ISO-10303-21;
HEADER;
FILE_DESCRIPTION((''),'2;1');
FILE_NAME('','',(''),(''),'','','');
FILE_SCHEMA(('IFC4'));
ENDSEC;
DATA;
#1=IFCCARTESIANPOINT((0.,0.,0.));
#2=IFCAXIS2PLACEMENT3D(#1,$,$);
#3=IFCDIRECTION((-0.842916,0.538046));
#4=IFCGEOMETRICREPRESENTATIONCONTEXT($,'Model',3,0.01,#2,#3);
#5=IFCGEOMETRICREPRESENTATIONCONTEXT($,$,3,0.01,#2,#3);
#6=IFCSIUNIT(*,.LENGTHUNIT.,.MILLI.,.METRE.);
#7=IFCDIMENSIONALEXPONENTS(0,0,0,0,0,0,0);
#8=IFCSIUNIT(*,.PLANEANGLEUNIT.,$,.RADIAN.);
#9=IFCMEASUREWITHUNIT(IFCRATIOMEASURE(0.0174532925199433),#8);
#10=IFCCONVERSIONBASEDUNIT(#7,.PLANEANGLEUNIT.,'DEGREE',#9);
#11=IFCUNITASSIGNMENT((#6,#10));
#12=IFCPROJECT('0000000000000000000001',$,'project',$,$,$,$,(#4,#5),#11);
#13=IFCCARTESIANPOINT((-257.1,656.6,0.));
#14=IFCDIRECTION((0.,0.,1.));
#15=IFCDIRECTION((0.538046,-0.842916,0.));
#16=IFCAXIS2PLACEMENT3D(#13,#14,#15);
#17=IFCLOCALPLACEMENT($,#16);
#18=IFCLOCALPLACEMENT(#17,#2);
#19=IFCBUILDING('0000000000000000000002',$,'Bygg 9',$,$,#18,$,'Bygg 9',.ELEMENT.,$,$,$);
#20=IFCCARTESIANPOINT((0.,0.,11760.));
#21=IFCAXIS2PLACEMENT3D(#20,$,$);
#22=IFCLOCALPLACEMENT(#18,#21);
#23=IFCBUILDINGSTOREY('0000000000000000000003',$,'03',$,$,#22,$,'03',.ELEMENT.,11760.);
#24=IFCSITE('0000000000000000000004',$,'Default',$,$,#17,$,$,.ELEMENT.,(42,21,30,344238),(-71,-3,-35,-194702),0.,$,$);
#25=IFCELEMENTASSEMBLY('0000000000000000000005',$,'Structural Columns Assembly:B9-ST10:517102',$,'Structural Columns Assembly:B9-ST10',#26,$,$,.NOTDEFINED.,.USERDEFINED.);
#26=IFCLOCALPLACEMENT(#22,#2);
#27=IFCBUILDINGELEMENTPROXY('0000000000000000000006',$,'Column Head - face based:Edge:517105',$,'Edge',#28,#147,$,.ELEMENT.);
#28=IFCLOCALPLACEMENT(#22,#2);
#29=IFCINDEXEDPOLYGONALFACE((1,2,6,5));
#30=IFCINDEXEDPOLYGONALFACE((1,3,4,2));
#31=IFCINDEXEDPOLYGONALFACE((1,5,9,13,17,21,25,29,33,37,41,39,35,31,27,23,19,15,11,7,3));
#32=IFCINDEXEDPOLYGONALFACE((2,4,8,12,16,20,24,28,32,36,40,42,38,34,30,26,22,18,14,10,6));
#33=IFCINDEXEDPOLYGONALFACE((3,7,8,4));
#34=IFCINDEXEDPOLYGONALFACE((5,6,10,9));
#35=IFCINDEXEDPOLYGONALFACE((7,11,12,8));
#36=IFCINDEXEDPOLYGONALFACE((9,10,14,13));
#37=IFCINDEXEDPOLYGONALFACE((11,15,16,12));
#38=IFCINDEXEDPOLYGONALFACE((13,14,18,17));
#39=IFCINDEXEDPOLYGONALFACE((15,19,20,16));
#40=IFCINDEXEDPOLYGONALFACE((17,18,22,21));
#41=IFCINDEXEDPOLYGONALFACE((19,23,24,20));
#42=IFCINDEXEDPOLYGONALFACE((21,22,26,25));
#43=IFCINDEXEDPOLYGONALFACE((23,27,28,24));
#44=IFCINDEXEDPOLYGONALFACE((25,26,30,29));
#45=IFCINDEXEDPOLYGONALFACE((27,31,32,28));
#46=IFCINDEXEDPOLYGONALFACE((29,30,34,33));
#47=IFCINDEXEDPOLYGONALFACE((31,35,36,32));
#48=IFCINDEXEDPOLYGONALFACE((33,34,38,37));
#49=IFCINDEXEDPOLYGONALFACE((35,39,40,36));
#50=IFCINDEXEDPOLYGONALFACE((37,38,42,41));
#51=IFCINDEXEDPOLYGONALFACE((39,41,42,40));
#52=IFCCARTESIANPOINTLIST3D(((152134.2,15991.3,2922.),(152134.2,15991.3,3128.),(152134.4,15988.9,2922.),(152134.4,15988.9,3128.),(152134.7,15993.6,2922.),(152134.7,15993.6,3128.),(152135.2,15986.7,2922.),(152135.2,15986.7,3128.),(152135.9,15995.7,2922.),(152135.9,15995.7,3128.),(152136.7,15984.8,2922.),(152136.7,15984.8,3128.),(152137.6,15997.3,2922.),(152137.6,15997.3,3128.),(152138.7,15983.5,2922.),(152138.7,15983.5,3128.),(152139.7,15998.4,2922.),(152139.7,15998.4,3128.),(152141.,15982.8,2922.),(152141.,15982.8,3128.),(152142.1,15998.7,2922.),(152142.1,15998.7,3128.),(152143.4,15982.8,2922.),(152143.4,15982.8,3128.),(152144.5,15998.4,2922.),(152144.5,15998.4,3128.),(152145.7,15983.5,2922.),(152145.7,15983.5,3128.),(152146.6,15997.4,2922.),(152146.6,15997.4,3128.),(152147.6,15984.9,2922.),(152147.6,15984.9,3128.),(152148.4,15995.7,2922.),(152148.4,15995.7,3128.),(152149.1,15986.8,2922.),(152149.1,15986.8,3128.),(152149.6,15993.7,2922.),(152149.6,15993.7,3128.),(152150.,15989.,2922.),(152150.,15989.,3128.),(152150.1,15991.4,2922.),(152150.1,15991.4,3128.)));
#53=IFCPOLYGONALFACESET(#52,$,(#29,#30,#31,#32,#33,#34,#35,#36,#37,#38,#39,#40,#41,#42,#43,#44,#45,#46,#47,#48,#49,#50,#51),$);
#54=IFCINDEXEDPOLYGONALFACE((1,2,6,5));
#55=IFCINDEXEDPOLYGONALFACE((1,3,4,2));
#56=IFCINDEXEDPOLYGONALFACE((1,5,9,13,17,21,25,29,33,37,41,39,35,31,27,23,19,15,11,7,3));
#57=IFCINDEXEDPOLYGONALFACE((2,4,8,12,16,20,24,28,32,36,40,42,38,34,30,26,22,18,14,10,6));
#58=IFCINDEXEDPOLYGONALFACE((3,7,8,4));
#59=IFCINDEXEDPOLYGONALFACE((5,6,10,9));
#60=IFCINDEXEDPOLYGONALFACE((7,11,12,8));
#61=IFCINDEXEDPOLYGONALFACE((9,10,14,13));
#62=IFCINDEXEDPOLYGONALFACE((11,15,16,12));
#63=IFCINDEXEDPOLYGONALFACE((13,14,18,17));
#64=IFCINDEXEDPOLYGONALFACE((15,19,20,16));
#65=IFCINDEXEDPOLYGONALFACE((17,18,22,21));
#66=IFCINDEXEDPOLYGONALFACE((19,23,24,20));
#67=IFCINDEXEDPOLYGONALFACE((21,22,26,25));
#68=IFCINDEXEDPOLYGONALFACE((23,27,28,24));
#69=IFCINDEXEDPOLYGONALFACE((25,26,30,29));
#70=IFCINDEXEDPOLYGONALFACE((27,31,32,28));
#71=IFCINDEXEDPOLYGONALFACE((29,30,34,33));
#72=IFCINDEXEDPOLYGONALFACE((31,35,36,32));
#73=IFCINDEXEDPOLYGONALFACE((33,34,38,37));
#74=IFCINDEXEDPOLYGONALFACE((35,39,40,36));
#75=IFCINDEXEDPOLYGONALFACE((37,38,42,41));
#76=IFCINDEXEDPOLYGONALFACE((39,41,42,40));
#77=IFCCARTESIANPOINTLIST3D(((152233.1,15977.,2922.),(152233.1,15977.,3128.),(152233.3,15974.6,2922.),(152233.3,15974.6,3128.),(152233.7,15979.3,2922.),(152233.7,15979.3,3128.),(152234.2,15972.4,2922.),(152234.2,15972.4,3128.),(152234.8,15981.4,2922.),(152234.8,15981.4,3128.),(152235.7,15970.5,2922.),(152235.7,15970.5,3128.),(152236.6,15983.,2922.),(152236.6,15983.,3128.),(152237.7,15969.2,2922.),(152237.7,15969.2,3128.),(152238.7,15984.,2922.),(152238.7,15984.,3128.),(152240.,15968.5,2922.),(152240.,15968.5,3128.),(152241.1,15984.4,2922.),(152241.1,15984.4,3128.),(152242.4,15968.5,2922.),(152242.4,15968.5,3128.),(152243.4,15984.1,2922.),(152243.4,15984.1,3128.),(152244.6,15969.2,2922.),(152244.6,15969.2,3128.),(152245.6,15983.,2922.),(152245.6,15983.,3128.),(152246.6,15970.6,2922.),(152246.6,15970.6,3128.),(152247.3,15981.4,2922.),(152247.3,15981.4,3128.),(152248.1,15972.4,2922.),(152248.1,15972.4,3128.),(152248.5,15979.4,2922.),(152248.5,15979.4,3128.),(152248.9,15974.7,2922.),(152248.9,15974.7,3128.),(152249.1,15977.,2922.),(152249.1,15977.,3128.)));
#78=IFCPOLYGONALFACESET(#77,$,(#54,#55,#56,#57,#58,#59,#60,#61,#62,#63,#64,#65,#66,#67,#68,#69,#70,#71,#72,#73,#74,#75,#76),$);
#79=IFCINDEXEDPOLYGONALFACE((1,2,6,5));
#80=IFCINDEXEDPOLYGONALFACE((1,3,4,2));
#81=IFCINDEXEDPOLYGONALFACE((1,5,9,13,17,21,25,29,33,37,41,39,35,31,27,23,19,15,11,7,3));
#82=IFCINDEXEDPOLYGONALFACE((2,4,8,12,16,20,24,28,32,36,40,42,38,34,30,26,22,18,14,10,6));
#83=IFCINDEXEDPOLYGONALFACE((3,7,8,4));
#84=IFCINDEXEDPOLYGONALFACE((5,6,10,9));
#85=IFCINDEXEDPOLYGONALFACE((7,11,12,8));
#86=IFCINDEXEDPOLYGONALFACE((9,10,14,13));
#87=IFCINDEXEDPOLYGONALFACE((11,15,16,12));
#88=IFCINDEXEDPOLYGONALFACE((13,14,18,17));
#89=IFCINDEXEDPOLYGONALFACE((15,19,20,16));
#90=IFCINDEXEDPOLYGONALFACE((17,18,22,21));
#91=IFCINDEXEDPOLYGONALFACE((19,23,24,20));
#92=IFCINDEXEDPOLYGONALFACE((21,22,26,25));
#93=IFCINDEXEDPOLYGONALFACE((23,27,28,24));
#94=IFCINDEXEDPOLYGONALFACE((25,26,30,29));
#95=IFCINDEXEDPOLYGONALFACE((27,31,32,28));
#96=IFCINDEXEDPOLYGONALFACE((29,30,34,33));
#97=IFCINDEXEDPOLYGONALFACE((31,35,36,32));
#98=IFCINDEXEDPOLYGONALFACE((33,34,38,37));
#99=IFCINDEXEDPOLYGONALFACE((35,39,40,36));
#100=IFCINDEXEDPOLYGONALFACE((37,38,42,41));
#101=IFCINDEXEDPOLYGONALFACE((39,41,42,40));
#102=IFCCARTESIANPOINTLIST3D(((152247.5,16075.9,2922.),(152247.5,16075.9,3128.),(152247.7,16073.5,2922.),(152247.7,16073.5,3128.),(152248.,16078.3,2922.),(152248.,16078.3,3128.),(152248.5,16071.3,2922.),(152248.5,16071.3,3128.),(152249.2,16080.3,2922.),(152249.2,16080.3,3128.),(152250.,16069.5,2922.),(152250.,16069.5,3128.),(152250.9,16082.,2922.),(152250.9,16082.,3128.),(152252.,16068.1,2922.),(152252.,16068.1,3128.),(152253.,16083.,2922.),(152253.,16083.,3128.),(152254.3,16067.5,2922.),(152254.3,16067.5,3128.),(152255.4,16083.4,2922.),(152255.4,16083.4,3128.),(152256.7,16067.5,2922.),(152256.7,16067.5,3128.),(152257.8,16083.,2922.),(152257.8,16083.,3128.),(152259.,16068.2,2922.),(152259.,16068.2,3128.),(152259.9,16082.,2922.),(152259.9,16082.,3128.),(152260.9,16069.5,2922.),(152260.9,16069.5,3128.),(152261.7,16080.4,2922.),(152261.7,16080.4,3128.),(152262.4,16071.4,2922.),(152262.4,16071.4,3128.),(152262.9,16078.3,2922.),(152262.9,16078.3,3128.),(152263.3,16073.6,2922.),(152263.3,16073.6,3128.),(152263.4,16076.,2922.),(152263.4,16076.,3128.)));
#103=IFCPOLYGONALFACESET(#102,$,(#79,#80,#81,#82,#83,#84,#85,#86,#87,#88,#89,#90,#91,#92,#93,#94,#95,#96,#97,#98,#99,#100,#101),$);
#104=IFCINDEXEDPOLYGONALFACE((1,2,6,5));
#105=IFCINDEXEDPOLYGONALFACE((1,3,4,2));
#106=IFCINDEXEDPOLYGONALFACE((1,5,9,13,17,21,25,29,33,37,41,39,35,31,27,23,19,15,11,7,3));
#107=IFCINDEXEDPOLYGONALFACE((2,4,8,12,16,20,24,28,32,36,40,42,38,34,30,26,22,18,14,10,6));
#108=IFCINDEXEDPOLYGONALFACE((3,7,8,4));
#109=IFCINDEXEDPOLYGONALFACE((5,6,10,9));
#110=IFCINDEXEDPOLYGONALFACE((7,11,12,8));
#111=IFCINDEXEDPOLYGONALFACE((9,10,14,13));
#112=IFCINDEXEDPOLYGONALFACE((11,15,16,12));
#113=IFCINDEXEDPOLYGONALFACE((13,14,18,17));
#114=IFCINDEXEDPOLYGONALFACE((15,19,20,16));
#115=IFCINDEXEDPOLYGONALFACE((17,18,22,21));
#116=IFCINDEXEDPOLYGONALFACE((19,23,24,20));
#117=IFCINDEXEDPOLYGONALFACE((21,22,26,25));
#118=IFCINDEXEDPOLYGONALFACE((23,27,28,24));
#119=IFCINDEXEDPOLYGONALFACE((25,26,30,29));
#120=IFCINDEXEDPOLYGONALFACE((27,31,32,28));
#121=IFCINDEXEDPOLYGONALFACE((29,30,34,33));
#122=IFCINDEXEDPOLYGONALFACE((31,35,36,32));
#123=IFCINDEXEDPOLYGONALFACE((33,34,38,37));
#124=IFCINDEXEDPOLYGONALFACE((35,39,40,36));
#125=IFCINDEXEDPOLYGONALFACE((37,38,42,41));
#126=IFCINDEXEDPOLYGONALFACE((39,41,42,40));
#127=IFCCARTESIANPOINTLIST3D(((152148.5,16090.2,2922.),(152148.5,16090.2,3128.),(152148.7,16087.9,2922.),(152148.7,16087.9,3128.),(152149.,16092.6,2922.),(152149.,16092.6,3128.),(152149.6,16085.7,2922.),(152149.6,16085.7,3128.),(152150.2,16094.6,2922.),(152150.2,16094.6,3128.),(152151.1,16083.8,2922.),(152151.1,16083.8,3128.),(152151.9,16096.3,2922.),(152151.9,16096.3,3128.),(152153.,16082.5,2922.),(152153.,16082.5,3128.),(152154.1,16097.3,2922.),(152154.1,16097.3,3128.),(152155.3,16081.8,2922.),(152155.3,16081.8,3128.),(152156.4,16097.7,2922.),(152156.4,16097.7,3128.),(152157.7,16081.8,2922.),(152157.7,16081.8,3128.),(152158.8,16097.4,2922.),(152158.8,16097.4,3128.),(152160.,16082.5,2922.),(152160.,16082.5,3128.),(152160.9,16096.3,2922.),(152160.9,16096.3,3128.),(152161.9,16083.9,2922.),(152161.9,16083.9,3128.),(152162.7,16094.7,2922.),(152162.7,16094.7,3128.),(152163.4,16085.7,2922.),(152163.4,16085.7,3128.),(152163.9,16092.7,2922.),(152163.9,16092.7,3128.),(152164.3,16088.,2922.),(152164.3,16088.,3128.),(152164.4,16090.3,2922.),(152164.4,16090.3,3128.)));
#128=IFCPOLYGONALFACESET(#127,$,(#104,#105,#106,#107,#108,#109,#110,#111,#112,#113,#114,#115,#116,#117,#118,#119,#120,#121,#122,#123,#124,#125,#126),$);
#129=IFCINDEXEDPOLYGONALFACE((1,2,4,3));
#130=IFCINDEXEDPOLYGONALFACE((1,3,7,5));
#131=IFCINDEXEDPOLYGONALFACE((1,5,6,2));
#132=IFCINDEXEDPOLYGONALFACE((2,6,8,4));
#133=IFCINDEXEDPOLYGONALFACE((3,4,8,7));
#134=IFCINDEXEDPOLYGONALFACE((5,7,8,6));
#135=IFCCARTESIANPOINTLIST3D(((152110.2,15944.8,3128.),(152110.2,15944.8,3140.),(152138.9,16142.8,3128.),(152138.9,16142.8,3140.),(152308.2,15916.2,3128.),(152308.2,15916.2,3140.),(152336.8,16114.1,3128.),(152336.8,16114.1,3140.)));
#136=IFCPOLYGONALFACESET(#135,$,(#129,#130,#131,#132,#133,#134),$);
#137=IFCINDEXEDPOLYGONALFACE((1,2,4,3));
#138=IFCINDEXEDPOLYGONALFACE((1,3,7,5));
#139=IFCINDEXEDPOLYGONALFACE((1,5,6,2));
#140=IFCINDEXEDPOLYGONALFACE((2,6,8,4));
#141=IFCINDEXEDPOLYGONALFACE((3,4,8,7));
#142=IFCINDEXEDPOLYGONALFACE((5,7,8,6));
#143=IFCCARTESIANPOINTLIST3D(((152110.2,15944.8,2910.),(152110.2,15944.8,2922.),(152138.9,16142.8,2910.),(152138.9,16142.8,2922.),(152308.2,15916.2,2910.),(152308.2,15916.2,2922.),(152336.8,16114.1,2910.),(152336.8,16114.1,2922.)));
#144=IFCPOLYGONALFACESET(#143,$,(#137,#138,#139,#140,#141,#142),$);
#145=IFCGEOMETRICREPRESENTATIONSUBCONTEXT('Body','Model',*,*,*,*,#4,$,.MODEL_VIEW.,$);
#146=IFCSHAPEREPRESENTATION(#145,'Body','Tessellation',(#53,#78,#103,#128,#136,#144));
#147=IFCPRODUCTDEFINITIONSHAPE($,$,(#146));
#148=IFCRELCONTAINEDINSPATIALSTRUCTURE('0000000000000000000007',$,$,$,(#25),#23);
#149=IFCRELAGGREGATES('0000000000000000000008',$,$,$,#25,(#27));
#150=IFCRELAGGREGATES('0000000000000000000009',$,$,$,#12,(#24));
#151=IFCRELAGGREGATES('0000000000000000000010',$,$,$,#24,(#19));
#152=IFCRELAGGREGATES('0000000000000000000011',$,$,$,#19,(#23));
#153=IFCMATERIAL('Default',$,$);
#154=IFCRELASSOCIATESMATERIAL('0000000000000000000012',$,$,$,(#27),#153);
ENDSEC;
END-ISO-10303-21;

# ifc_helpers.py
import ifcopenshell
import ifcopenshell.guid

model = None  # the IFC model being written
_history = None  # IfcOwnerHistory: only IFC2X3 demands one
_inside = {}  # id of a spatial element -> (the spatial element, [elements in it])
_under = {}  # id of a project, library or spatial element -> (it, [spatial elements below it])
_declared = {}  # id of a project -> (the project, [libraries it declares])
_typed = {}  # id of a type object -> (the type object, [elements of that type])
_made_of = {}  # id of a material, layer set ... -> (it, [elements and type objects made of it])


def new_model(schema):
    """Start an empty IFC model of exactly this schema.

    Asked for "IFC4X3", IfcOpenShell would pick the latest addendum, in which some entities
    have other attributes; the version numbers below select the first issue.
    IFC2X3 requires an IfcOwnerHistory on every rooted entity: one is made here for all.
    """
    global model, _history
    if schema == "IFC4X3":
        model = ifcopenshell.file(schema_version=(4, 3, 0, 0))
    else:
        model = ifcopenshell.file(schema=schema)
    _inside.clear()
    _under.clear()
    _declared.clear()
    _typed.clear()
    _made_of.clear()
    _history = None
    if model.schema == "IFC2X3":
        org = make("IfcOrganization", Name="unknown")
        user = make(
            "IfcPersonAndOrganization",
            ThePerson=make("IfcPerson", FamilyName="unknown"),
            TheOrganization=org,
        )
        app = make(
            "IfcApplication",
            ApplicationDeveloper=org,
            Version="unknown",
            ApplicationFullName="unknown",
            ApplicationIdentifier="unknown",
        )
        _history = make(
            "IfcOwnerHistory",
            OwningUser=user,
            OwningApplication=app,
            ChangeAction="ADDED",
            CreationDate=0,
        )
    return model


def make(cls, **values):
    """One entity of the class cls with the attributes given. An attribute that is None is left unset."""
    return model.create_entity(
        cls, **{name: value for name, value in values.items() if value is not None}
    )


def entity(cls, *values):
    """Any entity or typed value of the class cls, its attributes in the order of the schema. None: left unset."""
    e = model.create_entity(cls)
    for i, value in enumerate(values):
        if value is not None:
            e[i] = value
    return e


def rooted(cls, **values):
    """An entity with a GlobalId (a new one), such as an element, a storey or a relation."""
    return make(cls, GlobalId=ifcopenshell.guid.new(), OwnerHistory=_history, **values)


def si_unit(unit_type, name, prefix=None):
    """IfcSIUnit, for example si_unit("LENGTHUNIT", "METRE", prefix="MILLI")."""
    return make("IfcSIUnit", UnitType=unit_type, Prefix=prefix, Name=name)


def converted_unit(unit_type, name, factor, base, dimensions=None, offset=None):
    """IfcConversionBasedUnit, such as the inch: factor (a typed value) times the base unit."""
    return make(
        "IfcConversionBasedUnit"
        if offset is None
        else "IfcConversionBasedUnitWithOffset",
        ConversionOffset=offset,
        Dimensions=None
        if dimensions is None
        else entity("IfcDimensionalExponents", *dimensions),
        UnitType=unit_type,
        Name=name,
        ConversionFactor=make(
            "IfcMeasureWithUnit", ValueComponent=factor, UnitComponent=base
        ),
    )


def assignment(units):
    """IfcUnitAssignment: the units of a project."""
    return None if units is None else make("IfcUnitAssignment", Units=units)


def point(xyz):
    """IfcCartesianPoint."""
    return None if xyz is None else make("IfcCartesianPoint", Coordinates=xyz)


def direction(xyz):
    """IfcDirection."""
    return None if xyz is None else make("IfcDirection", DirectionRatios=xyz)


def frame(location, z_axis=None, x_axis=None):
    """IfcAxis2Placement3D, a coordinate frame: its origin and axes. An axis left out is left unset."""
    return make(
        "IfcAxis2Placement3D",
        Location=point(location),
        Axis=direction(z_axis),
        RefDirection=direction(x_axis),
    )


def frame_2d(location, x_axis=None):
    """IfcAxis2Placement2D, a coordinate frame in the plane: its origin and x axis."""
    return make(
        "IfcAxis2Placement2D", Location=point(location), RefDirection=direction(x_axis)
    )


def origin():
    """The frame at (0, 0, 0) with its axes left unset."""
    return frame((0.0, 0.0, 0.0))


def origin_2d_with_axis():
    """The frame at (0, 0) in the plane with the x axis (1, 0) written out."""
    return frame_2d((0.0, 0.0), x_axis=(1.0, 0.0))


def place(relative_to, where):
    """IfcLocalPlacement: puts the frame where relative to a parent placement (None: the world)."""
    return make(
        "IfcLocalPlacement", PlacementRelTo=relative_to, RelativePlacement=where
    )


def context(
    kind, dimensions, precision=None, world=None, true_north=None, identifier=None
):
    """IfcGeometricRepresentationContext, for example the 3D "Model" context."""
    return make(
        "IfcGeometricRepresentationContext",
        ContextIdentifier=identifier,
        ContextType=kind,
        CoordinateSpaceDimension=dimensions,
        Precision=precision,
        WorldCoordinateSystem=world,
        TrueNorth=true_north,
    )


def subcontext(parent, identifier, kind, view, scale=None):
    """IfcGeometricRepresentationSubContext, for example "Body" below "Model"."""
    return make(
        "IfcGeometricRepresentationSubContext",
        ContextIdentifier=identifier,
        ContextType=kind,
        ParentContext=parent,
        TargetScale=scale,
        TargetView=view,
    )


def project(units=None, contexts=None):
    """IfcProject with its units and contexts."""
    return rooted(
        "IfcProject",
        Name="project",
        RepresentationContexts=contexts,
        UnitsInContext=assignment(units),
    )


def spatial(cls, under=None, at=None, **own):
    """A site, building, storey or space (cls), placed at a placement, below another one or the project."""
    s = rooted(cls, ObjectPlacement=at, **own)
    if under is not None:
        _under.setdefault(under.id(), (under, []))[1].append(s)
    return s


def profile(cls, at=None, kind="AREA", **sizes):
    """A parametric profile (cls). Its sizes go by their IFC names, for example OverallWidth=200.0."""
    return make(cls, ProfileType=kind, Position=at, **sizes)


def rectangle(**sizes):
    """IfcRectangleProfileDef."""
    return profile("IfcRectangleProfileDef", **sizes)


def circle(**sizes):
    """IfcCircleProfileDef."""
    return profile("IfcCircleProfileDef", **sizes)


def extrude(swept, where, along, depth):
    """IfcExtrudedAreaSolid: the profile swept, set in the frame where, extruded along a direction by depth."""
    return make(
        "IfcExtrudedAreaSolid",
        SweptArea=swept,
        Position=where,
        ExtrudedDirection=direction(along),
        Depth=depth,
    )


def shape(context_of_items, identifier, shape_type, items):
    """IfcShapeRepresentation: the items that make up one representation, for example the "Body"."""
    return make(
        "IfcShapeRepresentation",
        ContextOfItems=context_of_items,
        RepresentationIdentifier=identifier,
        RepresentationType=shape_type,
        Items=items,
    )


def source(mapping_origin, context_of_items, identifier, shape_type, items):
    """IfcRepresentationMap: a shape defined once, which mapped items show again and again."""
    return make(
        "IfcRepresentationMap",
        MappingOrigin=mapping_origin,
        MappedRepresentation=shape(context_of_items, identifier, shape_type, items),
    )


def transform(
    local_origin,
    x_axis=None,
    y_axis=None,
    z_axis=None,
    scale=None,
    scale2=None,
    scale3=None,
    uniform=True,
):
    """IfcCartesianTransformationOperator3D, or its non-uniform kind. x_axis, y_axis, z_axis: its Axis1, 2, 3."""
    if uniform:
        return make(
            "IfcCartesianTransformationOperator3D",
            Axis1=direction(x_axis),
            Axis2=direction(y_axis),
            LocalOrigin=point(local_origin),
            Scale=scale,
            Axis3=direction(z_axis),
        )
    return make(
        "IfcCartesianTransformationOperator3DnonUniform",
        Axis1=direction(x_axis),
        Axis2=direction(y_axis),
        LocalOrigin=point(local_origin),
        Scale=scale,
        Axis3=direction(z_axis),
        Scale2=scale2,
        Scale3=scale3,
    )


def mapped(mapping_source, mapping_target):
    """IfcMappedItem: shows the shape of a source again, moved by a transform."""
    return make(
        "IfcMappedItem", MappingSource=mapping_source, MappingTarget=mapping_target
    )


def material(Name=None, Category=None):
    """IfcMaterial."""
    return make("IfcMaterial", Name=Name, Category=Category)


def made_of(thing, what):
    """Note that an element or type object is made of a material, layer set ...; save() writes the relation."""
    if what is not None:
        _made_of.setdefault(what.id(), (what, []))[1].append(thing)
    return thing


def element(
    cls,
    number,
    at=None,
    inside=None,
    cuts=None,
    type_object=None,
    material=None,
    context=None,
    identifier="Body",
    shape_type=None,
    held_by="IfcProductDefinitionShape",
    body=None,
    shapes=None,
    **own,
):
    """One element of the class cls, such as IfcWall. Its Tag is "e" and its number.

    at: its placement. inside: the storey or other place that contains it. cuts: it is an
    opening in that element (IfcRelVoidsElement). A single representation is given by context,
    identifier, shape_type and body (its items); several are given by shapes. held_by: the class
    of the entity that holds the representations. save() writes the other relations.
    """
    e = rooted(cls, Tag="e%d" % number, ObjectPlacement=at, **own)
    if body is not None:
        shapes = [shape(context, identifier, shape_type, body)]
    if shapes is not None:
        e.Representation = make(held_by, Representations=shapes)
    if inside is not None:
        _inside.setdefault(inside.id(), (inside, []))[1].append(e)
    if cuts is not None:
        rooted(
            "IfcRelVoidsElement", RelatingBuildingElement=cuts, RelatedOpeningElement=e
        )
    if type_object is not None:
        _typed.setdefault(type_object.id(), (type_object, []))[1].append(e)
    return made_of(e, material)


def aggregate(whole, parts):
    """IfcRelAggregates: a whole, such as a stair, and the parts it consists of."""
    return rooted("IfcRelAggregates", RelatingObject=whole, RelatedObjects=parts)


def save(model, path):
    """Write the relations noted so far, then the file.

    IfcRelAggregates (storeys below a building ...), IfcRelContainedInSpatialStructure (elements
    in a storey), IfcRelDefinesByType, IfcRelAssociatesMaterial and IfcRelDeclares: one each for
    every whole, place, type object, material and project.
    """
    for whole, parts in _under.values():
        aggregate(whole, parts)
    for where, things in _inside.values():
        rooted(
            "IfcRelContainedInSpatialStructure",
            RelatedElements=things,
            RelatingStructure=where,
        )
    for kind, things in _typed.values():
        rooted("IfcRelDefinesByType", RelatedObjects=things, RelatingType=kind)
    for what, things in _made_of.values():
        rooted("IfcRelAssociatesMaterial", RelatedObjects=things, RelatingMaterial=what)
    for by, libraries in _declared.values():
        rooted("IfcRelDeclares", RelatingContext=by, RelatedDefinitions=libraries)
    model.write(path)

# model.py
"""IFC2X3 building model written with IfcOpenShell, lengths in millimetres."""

from ifc_helpers import new_model, entity, si_unit, converted_unit, direction, frame, frame_2d, origin, origin_2d_with_axis, place, context, subcontext, project, spatial, rectangle, circle, extrude, source, transform, mapped, material, element, aggregate, save


model = new_model("IFC2X3")

# Units and contexts
model_context = context("Model", 3, precision=0.01, world=origin(), true_north=direction((-0.842916, 0.538046)))
context_of_model = context(None, 3, precision=0.01, world=origin(), true_north=direction((-0.842916, 0.538046)))
body_context = subcontext(model_context, "Body", "Model", "MODEL_VIEW")
ifc_project = project(units=[si_unit("LENGTHUNIT", "METRE", prefix="MILLI"), converted_unit("PLANEANGLEUNIT", "DEGREE", entity("IfcRatioMeasure", 0.0174532925199433), si_unit("PLANEANGLEUNIT", "RADIAN"), dimensions=[0, 0, 0, 0, 0, 0, 0])], contexts=[model_context, context_of_model])

# Site, building, storey
site_placement = place(None, frame((-257.1, 656.6, 0.0), z_axis=(0.0, 0.0, 1.0), x_axis=(0.538046, -0.842916, 0.0)))
site = spatial("IfcSite", under=ifc_project, at=site_placement, Name="Default", CompositionType="ELEMENT", RefLatitude=(42, 21, 30, 344238), RefLongitude=(-71, -3, -35, -194702), RefElevation=0.0)
building_placement = place(site_placement, origin())
building = spatial("IfcBuilding", under=site, at=building_placement, Name="Bygg 9", LongName="Bygg 9", CompositionType="ELEMENT")
storey_placement = place(building_placement, frame((0.0, 0.0, 11760.0)))
storey = spatial("IfcBuildingStorey", under=building, at=storey_placement, Name="03", LongName="03", CompositionType="ELEMENT", Elevation=11760.0)

# Element assembly
assembly_1_placement = place(storey_placement, origin())
assembly_1 = element("IfcElementAssembly", 1, at=assembly_1_placement, inside=storey, Name="Structural Columns Assembly:B9-ST10:517102", ObjectType="Structural Columns Assembly:B9-ST10", AssemblyPlace="NOTDEFINED", PredefinedType="USERDEFINED")

# Building element proxy
ifc_material_1 = material(Name="Default")
shared_shape_1 = source(origin(), body_context, "Body", "SweptSolid", [
    extrude(circle(Radius=8.0, at=frame_2d((0.0, 0.0), x_axis=(1.0, 0.0))), frame((50.0, -75.0, 12.0)), (0.0, 0.0, 1.0), 206.0),
    extrude(circle(Radius=8.0, at=frame_2d((0.0, 0.0), x_axis=(1.0, 0.0))), frame((50.0, 25.0, 12.0)), (0.0, 0.0, 1.0), 206.0),
    extrude(circle(Radius=8.0, at=frame_2d((0.0, 0.0), x_axis=(1.0, 0.0))), frame((-50.0, 25.0, 12.0)), (0.0, 0.0, 1.0), 206.0),
    extrude(circle(Radius=8.0, at=frame_2d((0.0, 0.0), x_axis=(1.0, 0.0))), frame((-50.0, -75.0, 12.0)), (0.0, 0.0, 1.0), 206.0),
    extrude(rectangle(XDim=200.0, YDim=200.0, at=origin_2d_with_axis()), frame((0.0, 0.0, 218.0), z_axis=(0.0, 0.0, 1.0), x_axis=(-1.0, 0.0, 0.0)), (0.0, 0.0, 1.0), 12.0),
    extrude(rectangle(XDim=200.0, YDim=200.0, at=origin_2d_with_axis()), frame((0.0, 0.0, 0.0), z_axis=(0.0, 0.0, 1.0), x_axis=(0.0, 1.0, 0.0)), (0.0, 0.0, 1.0), 12.0),
])
proxy_1_placement = place(assembly_1_placement, frame((152223.5, 16029.5, 2910.0), z_axis=(0.0, 0.0, 1.0), x_axis=(-0.143216, -0.989691, 0.0)))
proxy_1 = element("IfcBuildingElementProxy", 2, at=proxy_1_placement, material=ifc_material_1, Name="Column Head - face based:Edge:517105", ObjectType="Edge", CompositionType="ELEMENT", context=body_context, shape_type="MappedRepresentation", body=[
    mapped(shared_shape_1, transform((0.0, 0.0, 0.0), scale=1.0)),
])
aggregate(assembly_1, [proxy_1])

save(model, "model.ifc")
